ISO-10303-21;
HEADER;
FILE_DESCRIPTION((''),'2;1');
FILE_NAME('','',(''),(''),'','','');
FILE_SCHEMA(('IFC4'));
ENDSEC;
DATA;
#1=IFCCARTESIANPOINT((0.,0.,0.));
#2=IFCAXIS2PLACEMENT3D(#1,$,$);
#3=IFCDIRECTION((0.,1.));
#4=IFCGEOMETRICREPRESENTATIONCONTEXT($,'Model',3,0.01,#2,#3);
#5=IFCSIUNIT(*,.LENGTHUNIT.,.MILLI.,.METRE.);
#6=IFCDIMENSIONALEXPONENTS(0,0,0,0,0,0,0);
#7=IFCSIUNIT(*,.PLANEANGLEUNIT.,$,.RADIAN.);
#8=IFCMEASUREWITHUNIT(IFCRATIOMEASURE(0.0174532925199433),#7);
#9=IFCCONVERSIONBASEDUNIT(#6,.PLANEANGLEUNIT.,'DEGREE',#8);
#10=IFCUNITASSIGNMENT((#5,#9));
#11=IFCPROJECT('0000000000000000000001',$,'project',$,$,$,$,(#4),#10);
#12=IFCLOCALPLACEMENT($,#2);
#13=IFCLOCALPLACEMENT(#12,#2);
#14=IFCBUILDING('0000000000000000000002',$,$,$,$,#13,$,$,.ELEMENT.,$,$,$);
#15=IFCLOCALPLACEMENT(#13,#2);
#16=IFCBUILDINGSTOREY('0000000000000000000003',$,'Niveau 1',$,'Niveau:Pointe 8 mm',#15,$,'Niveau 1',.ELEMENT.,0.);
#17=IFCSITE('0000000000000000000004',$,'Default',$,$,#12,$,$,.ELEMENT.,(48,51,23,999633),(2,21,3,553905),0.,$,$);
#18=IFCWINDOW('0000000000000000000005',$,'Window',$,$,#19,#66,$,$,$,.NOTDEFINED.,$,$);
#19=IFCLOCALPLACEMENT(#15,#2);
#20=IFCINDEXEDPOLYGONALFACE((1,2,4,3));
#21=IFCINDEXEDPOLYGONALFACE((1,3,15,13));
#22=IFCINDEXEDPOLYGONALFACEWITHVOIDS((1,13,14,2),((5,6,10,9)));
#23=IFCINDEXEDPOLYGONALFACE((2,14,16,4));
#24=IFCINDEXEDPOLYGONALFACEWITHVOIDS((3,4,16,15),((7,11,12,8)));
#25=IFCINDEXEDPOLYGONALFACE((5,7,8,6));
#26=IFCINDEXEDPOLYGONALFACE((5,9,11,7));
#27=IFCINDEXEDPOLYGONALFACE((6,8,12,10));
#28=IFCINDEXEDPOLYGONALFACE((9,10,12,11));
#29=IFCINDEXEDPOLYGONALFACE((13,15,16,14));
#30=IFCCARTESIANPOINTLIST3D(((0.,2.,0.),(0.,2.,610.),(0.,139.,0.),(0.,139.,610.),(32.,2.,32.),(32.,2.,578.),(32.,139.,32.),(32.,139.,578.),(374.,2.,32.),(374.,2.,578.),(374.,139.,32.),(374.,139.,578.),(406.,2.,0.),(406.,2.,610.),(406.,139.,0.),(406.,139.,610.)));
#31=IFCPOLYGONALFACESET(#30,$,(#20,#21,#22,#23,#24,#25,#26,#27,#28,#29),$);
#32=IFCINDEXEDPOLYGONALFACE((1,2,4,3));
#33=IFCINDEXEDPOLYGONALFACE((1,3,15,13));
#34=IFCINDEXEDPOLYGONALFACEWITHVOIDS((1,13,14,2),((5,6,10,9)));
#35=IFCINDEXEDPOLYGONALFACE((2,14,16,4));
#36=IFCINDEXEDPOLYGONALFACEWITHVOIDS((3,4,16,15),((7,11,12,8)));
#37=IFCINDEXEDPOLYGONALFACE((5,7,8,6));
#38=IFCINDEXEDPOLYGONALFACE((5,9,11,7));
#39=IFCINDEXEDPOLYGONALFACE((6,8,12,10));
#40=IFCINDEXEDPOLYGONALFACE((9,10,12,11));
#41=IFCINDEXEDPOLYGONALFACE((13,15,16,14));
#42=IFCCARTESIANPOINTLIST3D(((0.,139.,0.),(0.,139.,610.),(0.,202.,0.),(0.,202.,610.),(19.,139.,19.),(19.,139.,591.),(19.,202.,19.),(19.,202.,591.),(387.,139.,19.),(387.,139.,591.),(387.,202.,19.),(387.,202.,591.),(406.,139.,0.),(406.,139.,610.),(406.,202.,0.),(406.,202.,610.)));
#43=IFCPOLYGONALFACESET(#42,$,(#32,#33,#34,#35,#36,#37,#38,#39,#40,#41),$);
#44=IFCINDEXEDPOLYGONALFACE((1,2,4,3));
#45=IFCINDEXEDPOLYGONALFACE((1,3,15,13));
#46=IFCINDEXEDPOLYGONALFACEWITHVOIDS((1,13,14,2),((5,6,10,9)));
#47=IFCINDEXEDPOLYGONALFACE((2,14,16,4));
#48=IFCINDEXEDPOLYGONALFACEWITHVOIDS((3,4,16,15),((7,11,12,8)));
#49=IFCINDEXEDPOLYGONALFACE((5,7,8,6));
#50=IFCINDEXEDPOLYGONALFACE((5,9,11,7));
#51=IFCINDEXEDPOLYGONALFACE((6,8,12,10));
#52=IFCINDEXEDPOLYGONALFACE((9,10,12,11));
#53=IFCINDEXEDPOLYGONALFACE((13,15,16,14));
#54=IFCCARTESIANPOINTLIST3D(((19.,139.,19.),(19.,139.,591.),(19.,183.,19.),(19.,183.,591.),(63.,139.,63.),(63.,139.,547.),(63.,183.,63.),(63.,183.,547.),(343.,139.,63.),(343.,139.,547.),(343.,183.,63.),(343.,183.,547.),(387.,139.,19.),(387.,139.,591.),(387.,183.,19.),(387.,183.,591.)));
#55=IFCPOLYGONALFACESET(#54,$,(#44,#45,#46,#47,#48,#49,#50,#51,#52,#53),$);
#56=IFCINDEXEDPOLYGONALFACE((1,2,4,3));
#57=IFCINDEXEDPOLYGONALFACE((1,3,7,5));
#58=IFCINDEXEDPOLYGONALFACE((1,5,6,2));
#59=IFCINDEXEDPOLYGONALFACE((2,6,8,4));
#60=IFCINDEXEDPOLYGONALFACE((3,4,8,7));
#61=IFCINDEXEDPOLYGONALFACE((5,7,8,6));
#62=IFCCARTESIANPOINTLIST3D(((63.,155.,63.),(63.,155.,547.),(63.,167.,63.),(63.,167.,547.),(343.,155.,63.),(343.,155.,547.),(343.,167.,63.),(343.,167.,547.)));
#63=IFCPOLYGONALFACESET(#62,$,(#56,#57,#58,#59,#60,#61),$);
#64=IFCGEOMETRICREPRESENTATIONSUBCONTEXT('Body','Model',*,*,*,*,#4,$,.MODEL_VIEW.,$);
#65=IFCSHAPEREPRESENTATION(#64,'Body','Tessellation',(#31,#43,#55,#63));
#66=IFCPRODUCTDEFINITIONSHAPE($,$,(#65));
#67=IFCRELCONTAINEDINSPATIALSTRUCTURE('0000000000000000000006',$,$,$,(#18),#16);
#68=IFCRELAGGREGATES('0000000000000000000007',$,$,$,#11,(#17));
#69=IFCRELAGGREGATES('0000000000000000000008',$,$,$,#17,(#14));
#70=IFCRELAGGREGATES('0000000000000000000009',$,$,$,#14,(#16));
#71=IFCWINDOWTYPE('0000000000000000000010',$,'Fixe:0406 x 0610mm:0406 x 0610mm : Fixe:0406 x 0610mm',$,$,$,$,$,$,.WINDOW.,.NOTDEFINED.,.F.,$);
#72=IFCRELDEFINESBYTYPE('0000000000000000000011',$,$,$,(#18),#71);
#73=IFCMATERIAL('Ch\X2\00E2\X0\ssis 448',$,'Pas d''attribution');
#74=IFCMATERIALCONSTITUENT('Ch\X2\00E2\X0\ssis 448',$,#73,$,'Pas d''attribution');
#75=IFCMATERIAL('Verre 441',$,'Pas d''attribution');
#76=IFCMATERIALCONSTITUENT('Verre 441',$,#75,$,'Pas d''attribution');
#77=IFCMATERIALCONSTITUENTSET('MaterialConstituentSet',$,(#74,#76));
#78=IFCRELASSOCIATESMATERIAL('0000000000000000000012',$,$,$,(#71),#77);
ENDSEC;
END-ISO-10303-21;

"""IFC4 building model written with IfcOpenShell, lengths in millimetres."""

from ifc_helpers import new_model, entity, si_unit, converted_unit, direction, frame, origin, origin_with_axes, origin_2d_with_axis, place, context, subcontext, project, spatial, polyline, rectangle, outline, extrude, source, transform, mapped, material, constituent, constituent_set, type_object, type_shapes, element, save


model = new_model("IFC4")

# Units and contexts
model_context = context("Model", 3, precision=0.01, world=origin(), true_north=direction((0.0, 1.0)))
body_context = subcontext(model_context, "Body", "Model", "MODEL_VIEW")
ifc_project = project(units=[si_unit("LENGTHUNIT", "METRE", prefix="MILLI"), converted_unit("PLANEANGLEUNIT", "DEGREE", entity("IfcRatioMeasure", 0.0174532925199433), si_unit("PLANEANGLEUNIT", "RADIAN"), dimensions=[0, 0, 0, 0, 0, 0, 0])], contexts=[model_context])

# Site, building, storey
site_placement = place(None, origin())
site = spatial("IfcSite", under=ifc_project, at=site_placement, Name="Default", CompositionType="ELEMENT", RefLatitude=(48, 51, 23, 999633), RefLongitude=(2, 21, 3, 553905), RefElevation=0.0)
building_placement = place(site_placement, origin())
building = spatial("IfcBuilding", under=site, at=building_placement, CompositionType="ELEMENT")
storey_placement = place(building_placement, origin())
storey = spatial("IfcBuildingStorey", under=building, at=storey_placement, Name="Niveau 1", ObjectType="Niveau:Pointe 8 mm", LongName="Niveau 1", CompositionType="ELEMENT", Elevation=0.0)

# Window
ifc_material_1 = material(Name="Châssis 448", Category="Pas d'attribution")
ifc_constituent_1 = constituent(ifc_material_1, Name="Châssis 448", Category="Pas d'attribution")
ifc_material_2 = material(Name="Verre 441", Category="Pas d'attribution")
ifc_constituent_2 = constituent(ifc_material_2, Name="Verre 441", Category="Pas d'attribution")
ifc_constituent_set = constituent_set(constituents=[ifc_constituent_1, ifc_constituent_2], Name="MaterialConstituentSet")
window_type = type_object("IfcWindowType", Name="Fixe:0406 x 0610mm:0406 x 0610mm : Fixe:0406 x 0610mm", ParameterTakesPrecedence=False, PartitioningType="NOTDEFINED", PredefinedType="WINDOW", material=ifc_constituent_set)
shared_shape = source(origin(), body_context, "Body", "SweptSolid", [
    extrude(outline(polyline([(-305.0, -203.0), (305.0, -203.0), (305.0, 203.0), (-305.0, 203.0), (-305.0, -203.0)]), holes=[polyline([(273.0, 171.0), (273.0, -171.0), (-273.0, -171.0), (-273.0, 171.0), (273.0, 171.0)])]), frame((203.0, 2.0, 305.0), z_axis=(0.0, 1.0, 0.0), x_axis=(0.0, 0.0, -1.0)), (0.0, 0.0, 1.0), 137.0),
    extrude(outline(polyline([(-305.0, -203.0), (305.0, -203.0), (305.0, 203.0), (-305.0, 203.0), (-305.0, -203.0)]), holes=[polyline([(286.0, 184.0), (286.0, -184.0), (-286.0, -184.0), (-286.0, 184.0), (286.0, 184.0)])]), frame((203.0, 139.0, 305.0), z_axis=(0.0, 1.0, 0.0), x_axis=(0.0, 0.0, -1.0)), (0.0, 0.0, 1.0), 63.0),
    extrude(outline(polyline([(-286.0, -184.0), (286.0, -184.0), (286.0, 184.0), (-286.0, 184.0), (-286.0, -184.0)]), holes=[polyline([(242.0, 140.0), (242.0, -140.0), (-242.0, -140.0), (-242.0, 140.0), (242.0, 140.0)])]), frame((203.0, 139.0, 305.0), z_axis=(0.0, 1.0, 0.0), x_axis=(0.0, 0.0, -1.0)), (0.0, 0.0, 1.0), 44.0),
    extrude(rectangle(XDim=280.0, YDim=12.0, at=origin_2d_with_axis()), frame((203.0, 161.0, 63.0)), (0.0, 0.0, 1.0), 484.0),
])
type_shapes(window_type, [shared_shape])
window_placement = place(storey_placement, origin_with_axes())
element("IfcWindow", 1, at=window_placement, inside=storey, type_object=window_type, Name="Window", PredefinedType="NOTDEFINED", context=body_context, shape_type="MappedRepresentation", body=[
    mapped(shared_shape, transform((0.0, 0.0, 0.0), x_axis=(1.0, 0.0, 0.0), y_axis=(0.0, 1.0, 0.0), z_axis=(0.0, 0.0, 1.0), scale=1.0)),
])

save(model, "model.ifc")
